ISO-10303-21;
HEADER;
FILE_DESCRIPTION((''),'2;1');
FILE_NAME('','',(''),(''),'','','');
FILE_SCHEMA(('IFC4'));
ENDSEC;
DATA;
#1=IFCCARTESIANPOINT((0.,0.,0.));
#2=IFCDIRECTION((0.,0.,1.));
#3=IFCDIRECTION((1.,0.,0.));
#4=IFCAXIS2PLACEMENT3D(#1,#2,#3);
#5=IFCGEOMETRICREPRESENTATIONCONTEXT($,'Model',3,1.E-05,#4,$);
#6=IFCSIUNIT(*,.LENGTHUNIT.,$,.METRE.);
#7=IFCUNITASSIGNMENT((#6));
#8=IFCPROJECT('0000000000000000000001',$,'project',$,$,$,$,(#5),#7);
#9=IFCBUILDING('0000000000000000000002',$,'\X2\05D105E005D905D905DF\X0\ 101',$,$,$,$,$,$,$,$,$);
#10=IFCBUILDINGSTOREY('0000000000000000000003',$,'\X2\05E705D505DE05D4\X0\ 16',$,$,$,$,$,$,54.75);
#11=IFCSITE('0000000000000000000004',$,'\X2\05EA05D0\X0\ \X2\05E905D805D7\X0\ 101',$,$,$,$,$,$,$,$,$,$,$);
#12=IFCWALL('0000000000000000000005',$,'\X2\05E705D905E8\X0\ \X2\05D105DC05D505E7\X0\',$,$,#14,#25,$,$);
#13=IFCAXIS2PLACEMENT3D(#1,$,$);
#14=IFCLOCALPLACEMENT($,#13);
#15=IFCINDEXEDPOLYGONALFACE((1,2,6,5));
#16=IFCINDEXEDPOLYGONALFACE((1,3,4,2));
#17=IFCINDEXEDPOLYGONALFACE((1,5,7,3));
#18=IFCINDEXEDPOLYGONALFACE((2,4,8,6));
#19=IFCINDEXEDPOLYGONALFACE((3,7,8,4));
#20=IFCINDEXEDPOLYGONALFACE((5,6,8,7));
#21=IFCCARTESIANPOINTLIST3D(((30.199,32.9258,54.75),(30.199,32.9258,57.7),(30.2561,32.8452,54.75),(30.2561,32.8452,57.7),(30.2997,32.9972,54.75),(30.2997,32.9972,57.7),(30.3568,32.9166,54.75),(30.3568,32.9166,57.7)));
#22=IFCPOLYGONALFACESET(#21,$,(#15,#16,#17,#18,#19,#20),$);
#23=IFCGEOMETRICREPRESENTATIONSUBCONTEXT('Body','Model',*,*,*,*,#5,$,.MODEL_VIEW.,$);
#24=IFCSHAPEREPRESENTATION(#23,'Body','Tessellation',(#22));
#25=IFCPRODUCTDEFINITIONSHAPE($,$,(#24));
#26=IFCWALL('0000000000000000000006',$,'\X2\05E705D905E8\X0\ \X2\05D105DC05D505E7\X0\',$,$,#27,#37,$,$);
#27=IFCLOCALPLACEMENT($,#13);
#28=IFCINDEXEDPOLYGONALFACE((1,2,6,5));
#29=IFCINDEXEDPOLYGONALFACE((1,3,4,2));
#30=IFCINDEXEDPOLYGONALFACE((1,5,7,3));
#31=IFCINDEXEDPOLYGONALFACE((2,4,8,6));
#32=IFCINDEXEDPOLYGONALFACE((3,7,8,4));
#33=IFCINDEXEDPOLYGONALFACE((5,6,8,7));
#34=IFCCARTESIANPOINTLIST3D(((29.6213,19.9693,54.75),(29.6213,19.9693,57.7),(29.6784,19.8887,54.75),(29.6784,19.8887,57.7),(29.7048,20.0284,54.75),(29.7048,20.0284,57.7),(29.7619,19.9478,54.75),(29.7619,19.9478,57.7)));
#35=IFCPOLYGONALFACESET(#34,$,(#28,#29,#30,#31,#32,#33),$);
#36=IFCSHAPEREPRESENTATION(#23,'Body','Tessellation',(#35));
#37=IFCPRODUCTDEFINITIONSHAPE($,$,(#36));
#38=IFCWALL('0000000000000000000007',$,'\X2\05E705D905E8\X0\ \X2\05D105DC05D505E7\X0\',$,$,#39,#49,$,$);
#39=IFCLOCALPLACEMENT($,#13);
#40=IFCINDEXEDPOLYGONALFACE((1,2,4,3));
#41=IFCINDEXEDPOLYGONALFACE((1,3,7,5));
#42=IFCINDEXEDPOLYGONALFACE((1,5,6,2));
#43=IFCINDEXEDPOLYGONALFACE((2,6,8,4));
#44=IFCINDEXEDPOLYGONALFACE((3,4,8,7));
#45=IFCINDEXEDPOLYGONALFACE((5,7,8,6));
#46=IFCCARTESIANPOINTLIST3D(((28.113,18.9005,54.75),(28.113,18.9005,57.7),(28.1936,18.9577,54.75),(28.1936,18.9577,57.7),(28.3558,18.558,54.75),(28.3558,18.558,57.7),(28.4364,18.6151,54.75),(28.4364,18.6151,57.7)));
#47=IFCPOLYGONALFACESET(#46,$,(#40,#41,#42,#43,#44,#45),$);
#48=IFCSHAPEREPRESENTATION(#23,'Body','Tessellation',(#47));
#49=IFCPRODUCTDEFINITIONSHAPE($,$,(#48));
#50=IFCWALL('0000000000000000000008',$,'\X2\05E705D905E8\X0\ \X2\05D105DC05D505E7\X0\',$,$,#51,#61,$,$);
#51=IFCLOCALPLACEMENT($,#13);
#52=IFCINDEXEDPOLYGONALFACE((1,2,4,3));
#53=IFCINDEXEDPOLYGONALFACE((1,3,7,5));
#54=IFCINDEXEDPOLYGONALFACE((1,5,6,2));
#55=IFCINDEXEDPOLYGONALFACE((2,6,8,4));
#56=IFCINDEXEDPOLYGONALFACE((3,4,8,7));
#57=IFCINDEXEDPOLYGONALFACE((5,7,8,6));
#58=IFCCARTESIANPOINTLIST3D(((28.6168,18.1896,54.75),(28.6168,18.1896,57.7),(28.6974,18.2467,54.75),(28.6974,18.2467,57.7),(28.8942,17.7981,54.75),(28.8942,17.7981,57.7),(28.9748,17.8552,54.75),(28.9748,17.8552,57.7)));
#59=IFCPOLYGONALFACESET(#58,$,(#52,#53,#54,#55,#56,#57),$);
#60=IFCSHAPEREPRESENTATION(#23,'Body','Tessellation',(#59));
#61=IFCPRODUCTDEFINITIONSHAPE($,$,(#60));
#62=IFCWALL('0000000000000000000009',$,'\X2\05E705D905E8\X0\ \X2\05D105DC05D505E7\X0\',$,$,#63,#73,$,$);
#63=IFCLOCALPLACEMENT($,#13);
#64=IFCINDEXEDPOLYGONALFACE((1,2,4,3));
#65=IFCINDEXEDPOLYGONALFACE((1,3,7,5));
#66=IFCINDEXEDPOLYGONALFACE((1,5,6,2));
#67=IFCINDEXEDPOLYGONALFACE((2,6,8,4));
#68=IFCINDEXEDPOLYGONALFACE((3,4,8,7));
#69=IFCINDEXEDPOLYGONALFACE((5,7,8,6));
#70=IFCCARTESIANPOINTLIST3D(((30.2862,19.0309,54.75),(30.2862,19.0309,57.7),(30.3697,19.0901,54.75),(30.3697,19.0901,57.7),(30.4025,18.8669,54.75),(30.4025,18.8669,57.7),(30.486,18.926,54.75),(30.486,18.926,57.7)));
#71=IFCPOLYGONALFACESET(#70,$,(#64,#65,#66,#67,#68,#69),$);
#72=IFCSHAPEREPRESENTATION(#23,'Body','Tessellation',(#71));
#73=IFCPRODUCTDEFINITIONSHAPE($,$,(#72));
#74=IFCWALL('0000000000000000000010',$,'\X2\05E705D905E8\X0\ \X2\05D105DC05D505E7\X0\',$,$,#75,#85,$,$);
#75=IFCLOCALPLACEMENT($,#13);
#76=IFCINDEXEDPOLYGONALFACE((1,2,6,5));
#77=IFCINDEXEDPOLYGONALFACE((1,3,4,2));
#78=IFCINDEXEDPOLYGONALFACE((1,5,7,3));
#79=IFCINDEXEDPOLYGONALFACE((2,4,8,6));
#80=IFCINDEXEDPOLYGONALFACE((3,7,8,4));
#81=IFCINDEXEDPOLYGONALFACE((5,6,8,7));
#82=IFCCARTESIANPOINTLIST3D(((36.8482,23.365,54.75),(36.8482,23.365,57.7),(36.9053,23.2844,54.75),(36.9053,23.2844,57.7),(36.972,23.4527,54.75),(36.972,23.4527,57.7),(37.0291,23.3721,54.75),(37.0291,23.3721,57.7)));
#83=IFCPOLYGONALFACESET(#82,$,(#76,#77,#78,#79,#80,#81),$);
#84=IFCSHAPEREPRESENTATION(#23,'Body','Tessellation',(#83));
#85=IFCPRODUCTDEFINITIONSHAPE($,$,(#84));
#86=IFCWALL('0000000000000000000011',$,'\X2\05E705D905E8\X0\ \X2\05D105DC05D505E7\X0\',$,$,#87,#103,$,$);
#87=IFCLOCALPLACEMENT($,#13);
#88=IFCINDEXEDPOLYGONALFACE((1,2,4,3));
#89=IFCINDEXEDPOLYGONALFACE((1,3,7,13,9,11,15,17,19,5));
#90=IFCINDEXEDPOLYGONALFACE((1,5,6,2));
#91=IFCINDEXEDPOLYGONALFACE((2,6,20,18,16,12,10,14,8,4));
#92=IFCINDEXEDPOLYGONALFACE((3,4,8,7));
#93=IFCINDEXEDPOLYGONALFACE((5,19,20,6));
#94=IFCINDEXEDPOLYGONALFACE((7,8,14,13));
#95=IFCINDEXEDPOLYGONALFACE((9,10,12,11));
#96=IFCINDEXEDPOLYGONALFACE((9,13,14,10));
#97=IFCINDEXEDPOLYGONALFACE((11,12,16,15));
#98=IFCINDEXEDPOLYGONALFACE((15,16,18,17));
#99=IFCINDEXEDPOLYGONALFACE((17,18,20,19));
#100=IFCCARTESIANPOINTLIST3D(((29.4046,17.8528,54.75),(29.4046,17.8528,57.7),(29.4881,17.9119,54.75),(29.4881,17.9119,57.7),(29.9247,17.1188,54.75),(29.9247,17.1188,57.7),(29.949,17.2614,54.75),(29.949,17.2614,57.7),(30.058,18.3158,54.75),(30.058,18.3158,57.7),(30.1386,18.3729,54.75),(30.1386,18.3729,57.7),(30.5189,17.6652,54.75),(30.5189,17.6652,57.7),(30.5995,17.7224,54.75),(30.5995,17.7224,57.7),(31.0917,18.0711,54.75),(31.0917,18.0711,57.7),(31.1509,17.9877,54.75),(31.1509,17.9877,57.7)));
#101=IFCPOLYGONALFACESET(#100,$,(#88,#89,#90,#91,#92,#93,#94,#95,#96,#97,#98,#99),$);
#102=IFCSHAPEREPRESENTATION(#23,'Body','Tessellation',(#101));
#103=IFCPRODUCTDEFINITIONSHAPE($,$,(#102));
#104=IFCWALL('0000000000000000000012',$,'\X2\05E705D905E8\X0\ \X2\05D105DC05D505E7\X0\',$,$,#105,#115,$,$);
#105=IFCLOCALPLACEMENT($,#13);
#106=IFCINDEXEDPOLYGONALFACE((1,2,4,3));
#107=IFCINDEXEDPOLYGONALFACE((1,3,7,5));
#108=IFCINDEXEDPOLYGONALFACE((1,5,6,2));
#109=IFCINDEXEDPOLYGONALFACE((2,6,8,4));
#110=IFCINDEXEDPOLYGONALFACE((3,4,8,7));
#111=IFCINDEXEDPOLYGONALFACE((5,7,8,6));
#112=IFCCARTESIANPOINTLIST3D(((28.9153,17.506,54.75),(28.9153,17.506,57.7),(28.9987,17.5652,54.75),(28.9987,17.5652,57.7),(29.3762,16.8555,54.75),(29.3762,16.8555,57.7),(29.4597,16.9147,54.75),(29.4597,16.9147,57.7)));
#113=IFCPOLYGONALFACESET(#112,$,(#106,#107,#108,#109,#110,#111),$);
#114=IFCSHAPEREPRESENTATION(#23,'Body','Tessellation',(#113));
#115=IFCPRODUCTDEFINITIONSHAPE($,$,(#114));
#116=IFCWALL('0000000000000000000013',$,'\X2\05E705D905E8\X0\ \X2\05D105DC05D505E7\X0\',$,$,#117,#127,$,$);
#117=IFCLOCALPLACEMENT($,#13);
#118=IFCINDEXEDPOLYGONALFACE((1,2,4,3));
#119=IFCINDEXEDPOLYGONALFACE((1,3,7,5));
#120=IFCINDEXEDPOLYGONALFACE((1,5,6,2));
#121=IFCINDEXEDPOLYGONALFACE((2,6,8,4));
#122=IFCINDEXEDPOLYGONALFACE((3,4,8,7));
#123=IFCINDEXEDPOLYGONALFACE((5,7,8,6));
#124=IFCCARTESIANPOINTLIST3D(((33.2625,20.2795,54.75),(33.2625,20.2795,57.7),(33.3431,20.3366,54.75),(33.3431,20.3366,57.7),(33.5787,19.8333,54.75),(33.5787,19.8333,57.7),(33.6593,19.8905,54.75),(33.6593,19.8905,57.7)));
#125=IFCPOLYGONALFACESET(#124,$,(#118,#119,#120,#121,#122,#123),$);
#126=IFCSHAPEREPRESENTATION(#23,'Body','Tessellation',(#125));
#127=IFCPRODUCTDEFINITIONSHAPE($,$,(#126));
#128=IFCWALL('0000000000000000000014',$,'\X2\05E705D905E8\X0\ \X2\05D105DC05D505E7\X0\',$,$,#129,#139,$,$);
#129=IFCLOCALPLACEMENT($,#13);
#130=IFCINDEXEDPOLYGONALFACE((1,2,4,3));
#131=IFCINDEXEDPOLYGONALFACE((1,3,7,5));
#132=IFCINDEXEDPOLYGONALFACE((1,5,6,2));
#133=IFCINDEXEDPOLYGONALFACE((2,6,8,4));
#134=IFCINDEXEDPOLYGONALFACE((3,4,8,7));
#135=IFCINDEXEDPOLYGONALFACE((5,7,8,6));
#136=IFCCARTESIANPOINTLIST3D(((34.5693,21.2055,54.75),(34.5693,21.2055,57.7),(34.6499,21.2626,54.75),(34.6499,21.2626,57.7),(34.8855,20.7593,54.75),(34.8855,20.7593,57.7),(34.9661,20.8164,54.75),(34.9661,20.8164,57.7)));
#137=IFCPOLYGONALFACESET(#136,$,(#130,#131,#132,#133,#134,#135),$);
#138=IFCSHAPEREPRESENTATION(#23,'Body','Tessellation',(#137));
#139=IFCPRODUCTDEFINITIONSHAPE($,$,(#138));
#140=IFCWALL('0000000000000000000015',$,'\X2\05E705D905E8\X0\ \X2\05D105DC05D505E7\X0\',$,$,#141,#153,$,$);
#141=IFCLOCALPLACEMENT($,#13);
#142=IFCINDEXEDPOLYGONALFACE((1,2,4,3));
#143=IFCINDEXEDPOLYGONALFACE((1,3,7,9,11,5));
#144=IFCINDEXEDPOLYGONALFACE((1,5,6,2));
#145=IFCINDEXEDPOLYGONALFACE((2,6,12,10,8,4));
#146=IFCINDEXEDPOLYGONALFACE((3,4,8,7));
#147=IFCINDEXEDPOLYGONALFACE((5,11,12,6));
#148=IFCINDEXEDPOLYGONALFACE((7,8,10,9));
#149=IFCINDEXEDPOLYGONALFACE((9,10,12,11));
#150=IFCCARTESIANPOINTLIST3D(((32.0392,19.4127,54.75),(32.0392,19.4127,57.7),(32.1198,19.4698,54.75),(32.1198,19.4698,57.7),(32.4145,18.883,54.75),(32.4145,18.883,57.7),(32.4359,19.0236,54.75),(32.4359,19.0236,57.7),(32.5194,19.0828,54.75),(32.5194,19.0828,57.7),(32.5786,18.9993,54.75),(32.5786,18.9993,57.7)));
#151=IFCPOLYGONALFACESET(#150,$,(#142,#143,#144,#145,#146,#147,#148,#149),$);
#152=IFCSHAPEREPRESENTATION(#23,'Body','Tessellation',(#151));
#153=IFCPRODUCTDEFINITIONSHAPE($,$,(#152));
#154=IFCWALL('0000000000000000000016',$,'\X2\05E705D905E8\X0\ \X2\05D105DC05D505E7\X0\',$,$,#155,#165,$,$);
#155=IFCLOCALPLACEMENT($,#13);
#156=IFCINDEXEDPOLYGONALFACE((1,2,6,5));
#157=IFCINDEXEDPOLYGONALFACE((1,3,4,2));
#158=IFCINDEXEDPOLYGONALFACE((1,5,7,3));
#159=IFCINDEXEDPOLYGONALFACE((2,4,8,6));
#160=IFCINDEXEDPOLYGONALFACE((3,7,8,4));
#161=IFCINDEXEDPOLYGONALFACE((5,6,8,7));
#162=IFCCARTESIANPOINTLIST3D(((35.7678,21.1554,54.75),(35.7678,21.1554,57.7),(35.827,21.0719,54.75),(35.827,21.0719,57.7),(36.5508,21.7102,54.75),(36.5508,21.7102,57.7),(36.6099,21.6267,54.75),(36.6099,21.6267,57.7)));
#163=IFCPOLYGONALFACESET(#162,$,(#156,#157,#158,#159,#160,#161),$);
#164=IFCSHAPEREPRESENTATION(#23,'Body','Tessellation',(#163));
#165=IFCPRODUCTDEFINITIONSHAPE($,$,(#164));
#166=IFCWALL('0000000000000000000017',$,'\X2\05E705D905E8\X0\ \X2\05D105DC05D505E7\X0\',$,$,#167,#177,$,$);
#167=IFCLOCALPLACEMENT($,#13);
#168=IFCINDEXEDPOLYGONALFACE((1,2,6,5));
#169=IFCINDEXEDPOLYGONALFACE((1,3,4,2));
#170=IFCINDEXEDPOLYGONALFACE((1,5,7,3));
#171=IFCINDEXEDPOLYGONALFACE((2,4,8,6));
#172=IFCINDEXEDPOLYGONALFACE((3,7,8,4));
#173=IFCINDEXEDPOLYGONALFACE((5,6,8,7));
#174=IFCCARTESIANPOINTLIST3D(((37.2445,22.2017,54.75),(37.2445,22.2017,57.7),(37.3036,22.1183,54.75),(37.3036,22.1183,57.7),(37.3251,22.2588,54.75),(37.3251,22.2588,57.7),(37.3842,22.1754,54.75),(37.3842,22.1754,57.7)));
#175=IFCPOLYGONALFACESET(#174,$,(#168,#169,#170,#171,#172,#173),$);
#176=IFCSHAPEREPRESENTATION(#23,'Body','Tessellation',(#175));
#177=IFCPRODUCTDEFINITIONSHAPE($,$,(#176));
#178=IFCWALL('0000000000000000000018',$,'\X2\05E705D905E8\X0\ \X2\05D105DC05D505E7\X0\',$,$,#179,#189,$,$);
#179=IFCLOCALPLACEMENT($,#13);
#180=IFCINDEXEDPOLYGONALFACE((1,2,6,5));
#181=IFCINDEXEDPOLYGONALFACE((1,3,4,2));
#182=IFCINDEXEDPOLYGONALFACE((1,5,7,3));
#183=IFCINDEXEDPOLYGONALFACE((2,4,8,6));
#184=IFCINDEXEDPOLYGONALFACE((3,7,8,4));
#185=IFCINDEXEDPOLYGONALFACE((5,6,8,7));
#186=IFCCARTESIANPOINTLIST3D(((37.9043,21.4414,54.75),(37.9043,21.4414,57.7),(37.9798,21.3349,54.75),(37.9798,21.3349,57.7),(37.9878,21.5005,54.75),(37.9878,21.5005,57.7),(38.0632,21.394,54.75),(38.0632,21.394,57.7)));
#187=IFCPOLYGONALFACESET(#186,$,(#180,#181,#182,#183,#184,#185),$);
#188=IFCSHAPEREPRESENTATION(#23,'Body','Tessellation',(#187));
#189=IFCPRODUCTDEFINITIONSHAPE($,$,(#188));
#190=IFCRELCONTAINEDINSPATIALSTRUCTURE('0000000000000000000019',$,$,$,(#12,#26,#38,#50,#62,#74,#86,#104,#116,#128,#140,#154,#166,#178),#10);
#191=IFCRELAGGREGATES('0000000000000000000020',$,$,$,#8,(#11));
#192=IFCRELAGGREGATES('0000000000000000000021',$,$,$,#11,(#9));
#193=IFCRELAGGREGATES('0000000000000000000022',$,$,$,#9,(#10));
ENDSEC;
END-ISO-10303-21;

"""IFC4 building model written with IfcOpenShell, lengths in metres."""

from ifc_helpers import new_model, si_unit, frame, origin_with_axes, context, subcontext, project, spatial, polyline, outline, extrude, element, save


model = new_model("IFC4")

# Units and contexts
model_context = context("Model", 3, precision=1e-05, world=origin_with_axes())
body_context = subcontext(model_context, "Body", "Model", "MODEL_VIEW")
ifc_project = project(units=[si_unit("LENGTHUNIT", "METRE")], contexts=[model_context])

# Site, building, storey
site = spatial("IfcSite", under=ifc_project, Name="תא שטח 101")
building = spatial("IfcBuilding", under=site, Name="בניין 101")
storey = spatial("IfcBuildingStorey", under=building, Name="קומה 16", Elevation=54.75)

# Walls
element("IfcWall", 1, inside=storey, Name="קיר בלוק", context=body_context, shape_type="SweptSolid", body=[
    extrude(outline(polyline([(30.2997, 32.9972), (30.199, 32.9258), (30.2561, 32.8452), (30.3568, 32.9166), (30.2997, 32.9972)])), frame((0.0, 0.0, 54.75)), (0.0, 0.0, 1.0), 2.95),
])
element("IfcWall", 2, inside=storey, Name="קיר בלוק", context=body_context, shape_type="SweptSolid", body=[
    extrude(outline(polyline([(29.6784, 19.8887), (29.7619, 19.9478), (29.7048, 20.0284), (29.6213, 19.9693), (29.6784, 19.8887)])), frame((0.0, 0.0, 54.75)), (0.0, 0.0, 1.0), 2.95),
])
element("IfcWall", 3, inside=storey, Name="קיר בלוק", context=body_context, shape_type="SweptSolid", body=[
    extrude(outline(polyline([(28.113, 18.9005), (28.3558, 18.558), (28.4364, 18.6151), (28.1936, 18.9577), (28.113, 18.9005)])), frame((0.0, 0.0, 54.75)), (0.0, 0.0, 1.0), 2.95),
])
element("IfcWall", 4, inside=storey, Name="קיר בלוק", context=body_context, shape_type="SweptSolid", body=[
    extrude(outline(polyline([(28.6974, 18.2467), (28.6168, 18.1896), (28.8942, 17.7981), (28.9748, 17.8552), (28.6974, 18.2467)])), frame((0.0, 0.0, 54.75)), (0.0, 0.0, 1.0), 2.95),
])
element("IfcWall", 5, inside=storey, Name="קיר בלוק", context=body_context, shape_type="SweptSolid", body=[
    extrude(outline(polyline([(30.4025, 18.8669), (30.486, 18.926), (30.3697, 19.0901), (30.2862, 19.0309), (30.4025, 18.8669)])), frame((0.0, 0.0, 54.75)), (0.0, 0.0, 1.0), 2.95),
])
element("IfcWall", 6, inside=storey, Name="קיר בלוק", context=body_context, shape_type="SweptSolid", body=[
    extrude(outline(polyline([(36.8482, 23.365), (36.9053, 23.2844), (37.0291, 23.3721), (36.972, 23.4527), (36.8482, 23.365)])), frame((0.0, 0.0, 54.75)), (0.0, 0.0, 1.0), 2.95),
])
element("IfcWall", 7, inside=storey, Name="קיר בלוק", context=body_context, shape_type="SweptSolid", body=[
    extrude(outline(polyline([(30.5189, 17.6652), (29.949, 17.2614), (29.4881, 17.9119), (29.4046, 17.8528), (29.9247, 17.1188), (31.1509, 17.9877), (31.0917, 18.0711), (30.5995, 17.7224), (30.1386, 18.3729), (30.058, 18.3158), (30.5189, 17.6652)])), frame((0.0, 0.0, 54.75)), (0.0, 0.0, 1.0), 2.95),
])
element("IfcWall", 8, inside=storey, Name="קיר בלוק", context=body_context, shape_type="SweptSolid", body=[
    extrude(outline(polyline([(28.9987, 17.5652), (28.9153, 17.506), (29.3762, 16.8555), (29.4597, 16.9147), (28.9987, 17.5652)])), frame((0.0, 0.0, 54.75)), (0.0, 0.0, 1.0), 2.95),
])
element("IfcWall", 9, inside=storey, Name="קיר בלוק", context=body_context, shape_type="SweptSolid", body=[
    extrude(outline(polyline([(33.5787, 19.8333), (33.6593, 19.8905), (33.3431, 20.3366), (33.2625, 20.2795), (33.5787, 19.8333)])), frame((0.0, 0.0, 54.75)), (0.0, 0.0, 1.0), 2.95),
])
element("IfcWall", 10, inside=storey, Name="קיר בלוק", context=body_context, shape_type="SweptSolid", body=[
    extrude(outline(polyline([(34.9661, 20.8164), (34.6499, 21.2626), (34.5693, 21.2055), (34.8855, 20.7593), (34.9661, 20.8164)])), frame((0.0, 0.0, 54.75)), (0.0, 0.0, 1.0), 2.95),
])
element("IfcWall", 11, inside=storey, Name="קיר בלוק", context=body_context, shape_type="SweptSolid", body=[
    extrude(outline(polyline([(32.5194, 19.0828), (32.4359, 19.0236), (32.1198, 19.4698), (32.0392, 19.4127), (32.4145, 18.883), (32.5786, 18.9993), (32.5194, 19.0828)])), frame((0.0, 0.0, 54.75)), (0.0, 0.0, 1.0), 2.95),
])
element("IfcWall", 12, inside=storey, Name="קיר בלוק", context=body_context, shape_type="SweptSolid", body=[
    extrude(outline(polyline([(36.6099, 21.6267), (36.5508, 21.7102), (35.7678, 21.1554), (35.827, 21.0719), (36.6099, 21.6267)])), frame((0.0, 0.0, 54.75)), (0.0, 0.0, 1.0), 2.95),
])
element("IfcWall", 13, inside=storey, Name="קיר בלוק", context=body_context, shape_type="SweptSolid", body=[
    extrude(outline(polyline([(37.2445, 22.2017), (37.3036, 22.1183), (37.3842, 22.1754), (37.3251, 22.2588), (37.2445, 22.2017)])), frame((0.0, 0.0, 54.75)), (0.0, 0.0, 1.0), 2.95),
])
element("IfcWall", 14, inside=storey, Name="קיר בלוק", context=body_context, shape_type="SweptSolid", body=[
    extrude(outline(polyline([(37.9878, 21.5005), (37.9043, 21.4414), (37.9798, 21.3349), (38.0632, 21.394), (37.9878, 21.5005)])), frame((0.0, 0.0, 54.75)), (0.0, 0.0, 1.0), 2.95),
])

save(model, "model.ifc")
